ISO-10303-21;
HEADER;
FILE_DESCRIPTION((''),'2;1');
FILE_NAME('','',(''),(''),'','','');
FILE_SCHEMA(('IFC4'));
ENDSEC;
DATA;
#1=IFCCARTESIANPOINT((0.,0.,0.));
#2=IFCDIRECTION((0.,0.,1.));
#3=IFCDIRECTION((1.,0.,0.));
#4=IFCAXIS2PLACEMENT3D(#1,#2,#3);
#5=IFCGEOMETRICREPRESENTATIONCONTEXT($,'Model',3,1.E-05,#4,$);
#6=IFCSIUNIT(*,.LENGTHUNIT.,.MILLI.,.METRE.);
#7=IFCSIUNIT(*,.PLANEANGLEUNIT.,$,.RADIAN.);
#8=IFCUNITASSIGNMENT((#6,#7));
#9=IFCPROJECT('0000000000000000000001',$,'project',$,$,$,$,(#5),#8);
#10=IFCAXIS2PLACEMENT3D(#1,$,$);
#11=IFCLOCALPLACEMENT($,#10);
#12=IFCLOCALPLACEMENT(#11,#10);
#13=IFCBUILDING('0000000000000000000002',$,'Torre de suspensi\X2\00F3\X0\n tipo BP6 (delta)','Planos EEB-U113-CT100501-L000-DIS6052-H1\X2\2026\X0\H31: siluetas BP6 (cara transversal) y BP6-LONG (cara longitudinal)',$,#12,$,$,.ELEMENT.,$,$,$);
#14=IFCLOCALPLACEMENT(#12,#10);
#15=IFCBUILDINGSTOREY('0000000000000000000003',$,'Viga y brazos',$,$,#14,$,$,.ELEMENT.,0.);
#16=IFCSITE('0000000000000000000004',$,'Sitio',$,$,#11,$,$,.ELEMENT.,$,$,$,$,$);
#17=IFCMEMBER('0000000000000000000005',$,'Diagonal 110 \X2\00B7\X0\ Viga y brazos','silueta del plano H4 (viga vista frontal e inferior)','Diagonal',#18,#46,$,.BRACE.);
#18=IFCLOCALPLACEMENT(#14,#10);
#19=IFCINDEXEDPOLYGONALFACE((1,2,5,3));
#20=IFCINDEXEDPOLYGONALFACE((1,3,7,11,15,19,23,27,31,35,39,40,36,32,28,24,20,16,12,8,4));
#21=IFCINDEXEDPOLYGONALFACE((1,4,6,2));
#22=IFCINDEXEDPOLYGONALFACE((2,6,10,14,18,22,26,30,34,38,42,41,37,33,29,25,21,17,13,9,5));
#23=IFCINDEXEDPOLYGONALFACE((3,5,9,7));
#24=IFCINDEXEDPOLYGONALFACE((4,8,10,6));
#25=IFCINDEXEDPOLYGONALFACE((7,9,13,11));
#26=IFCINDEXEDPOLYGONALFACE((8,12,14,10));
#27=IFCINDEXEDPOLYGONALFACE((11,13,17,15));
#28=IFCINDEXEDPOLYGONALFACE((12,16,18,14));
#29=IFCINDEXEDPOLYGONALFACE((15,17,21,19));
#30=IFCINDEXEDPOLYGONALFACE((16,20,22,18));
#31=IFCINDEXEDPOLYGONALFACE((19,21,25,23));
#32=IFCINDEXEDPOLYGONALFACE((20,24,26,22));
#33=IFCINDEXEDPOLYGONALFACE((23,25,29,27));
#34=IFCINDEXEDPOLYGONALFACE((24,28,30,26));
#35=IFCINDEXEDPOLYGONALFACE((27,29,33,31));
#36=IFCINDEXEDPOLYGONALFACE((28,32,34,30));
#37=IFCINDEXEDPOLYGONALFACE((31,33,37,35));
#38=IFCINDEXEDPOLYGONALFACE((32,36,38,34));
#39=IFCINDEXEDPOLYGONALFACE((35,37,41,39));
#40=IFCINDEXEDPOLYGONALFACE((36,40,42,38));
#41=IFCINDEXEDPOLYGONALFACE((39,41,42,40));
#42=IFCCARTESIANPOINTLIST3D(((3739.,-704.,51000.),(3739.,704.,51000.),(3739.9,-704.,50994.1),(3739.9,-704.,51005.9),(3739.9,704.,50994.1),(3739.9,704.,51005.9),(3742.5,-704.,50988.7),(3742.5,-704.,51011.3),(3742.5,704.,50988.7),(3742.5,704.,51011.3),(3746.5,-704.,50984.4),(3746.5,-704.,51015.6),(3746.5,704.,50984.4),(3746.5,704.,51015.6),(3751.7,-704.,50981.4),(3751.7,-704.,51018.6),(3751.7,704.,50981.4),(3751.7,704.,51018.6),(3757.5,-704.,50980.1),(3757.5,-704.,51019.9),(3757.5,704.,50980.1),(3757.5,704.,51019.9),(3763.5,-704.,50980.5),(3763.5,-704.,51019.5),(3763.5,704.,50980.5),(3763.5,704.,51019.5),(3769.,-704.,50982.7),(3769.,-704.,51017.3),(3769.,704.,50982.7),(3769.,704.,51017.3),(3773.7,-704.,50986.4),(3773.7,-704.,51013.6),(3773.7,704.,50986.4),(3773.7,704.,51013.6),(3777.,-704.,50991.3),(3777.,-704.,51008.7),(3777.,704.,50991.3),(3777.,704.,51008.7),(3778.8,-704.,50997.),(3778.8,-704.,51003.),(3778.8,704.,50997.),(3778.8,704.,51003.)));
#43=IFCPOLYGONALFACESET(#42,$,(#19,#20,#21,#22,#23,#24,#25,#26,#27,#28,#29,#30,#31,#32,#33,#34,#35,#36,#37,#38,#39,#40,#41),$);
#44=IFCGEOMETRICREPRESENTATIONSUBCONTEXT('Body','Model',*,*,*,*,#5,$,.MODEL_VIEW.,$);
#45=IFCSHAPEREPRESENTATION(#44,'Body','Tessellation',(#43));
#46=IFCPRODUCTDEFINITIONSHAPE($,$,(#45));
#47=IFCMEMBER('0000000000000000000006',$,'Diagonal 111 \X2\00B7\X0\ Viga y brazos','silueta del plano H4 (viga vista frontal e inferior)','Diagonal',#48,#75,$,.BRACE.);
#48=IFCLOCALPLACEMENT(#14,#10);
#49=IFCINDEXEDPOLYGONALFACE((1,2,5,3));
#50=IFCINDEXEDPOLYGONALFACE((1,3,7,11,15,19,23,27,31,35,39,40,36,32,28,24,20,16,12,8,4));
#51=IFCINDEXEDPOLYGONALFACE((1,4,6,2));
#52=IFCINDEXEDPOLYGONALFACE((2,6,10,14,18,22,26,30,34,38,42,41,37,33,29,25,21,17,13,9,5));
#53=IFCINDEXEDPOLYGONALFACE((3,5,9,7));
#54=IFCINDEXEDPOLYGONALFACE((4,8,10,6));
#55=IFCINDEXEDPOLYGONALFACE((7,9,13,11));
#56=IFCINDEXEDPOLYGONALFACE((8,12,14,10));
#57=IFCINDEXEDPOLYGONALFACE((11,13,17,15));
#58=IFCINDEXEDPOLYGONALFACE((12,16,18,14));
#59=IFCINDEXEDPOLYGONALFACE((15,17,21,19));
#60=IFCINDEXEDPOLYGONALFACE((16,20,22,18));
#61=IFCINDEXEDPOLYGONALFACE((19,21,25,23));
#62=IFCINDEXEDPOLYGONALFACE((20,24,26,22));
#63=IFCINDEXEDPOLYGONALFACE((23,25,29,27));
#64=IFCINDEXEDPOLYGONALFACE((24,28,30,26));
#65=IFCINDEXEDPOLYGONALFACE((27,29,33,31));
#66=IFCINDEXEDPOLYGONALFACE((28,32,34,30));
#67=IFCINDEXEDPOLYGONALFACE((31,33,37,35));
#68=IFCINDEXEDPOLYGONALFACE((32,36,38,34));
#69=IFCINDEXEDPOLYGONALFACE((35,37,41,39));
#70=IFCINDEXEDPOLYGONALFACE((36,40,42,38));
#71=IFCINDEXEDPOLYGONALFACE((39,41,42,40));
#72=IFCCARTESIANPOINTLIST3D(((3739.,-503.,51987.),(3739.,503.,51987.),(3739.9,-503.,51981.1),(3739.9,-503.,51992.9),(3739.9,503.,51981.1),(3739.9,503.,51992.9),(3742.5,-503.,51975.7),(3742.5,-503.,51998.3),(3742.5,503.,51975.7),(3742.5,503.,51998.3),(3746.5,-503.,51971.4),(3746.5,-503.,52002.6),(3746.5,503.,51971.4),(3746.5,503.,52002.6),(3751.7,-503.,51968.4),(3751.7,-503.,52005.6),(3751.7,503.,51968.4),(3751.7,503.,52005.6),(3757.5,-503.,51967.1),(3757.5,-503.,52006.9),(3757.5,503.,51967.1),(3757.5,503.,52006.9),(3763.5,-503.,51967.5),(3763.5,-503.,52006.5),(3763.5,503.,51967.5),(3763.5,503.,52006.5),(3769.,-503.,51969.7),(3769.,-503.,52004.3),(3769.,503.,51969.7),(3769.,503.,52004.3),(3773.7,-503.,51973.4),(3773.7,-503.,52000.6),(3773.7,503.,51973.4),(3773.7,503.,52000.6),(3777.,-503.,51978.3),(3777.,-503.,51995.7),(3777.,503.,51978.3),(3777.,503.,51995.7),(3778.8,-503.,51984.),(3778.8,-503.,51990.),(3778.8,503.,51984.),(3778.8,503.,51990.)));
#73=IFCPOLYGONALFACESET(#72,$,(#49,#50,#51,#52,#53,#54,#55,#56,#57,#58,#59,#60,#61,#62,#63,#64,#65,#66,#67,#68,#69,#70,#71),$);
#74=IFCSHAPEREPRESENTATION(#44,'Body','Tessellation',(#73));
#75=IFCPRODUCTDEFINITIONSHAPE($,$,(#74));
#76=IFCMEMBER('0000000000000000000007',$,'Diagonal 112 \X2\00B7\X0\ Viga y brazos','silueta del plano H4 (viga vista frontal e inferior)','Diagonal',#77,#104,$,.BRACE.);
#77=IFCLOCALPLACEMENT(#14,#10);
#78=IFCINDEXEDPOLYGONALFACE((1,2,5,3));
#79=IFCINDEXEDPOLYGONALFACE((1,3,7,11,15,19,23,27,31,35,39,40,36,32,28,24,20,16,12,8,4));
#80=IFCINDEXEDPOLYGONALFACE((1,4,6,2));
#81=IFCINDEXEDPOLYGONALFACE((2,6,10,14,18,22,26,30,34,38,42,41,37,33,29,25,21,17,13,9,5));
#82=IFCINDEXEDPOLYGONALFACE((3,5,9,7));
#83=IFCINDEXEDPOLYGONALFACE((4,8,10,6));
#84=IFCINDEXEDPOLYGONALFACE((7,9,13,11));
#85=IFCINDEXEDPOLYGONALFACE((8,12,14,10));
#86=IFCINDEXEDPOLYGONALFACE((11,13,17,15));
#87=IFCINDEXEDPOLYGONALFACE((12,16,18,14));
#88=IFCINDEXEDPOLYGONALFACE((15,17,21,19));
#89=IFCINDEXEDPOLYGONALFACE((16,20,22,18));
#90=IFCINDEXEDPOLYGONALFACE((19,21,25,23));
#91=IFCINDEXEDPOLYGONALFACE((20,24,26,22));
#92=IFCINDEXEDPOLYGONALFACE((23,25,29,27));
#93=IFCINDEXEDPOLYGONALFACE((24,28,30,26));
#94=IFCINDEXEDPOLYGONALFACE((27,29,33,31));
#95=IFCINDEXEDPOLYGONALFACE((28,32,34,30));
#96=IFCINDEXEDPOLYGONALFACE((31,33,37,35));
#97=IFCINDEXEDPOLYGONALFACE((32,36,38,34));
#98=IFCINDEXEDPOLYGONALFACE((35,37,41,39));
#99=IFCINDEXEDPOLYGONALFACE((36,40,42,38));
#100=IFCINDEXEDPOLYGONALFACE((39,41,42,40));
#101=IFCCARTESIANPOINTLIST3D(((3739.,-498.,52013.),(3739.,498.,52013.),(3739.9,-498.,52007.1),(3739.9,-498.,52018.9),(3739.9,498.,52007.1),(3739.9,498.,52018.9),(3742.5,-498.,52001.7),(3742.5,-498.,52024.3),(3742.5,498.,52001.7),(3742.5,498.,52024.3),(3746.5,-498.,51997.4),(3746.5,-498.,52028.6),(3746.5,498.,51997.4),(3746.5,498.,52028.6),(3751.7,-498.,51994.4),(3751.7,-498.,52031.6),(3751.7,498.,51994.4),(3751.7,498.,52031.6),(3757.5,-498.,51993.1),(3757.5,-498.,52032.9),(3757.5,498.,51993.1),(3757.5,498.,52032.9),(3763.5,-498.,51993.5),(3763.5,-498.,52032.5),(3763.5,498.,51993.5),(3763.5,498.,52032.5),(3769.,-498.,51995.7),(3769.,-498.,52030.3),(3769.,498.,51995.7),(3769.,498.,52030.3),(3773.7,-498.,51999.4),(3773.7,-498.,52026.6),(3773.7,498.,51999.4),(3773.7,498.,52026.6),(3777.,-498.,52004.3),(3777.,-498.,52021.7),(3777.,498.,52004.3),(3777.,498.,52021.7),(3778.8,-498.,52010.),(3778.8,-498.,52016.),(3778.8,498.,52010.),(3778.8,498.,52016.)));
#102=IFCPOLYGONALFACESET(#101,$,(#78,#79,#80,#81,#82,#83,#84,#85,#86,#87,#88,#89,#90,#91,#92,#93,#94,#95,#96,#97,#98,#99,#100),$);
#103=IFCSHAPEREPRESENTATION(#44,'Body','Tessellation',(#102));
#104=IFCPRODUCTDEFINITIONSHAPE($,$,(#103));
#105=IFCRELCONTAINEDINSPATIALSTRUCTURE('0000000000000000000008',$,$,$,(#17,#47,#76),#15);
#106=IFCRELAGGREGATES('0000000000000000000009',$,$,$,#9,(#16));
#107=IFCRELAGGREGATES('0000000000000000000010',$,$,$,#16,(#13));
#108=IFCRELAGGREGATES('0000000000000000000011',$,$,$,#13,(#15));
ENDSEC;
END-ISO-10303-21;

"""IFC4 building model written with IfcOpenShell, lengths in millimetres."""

from ifc_helpers import new_model, si_unit, frame, origin, origin_with_axes, place, context, subcontext, project, spatial, circle, extrude, element, save


model = new_model("IFC4")

# Units and contexts
model_context = context("Model", 3, precision=1e-05, world=origin_with_axes())
body_context = subcontext(model_context, "Body", "Model", "MODEL_VIEW")
ifc_project = project(units=[si_unit("LENGTHUNIT", "METRE", prefix="MILLI"), si_unit("PLANEANGLEUNIT", "RADIAN")], contexts=[model_context])

# Site, building, storey
site_placement = place(None, origin())
site = spatial("IfcSite", under=ifc_project, at=site_placement, Name="Sitio", CompositionType="ELEMENT")
building_placement = place(site_placement, origin())
building = spatial("IfcBuilding", under=site, at=building_placement, Name="Torre de suspensión tipo BP6 (delta)", Description="Planos EEB-U113-CT100501-L000-DIS6052-H1…H31: siluetas BP6 (cara transversal) y BP6-LONG (cara longitudinal)", CompositionType="ELEMENT")
storey_placement = place(building_placement, origin())
storey = spatial("IfcBuildingStorey", under=building, at=storey_placement, Name="Viga y brazos", CompositionType="ELEMENT", Elevation=0.0)

# Members
for number, where, z_axis, x_axis, name in (
    (1, (3759.0, 704.0, 51000.0), (0.0, -1.0, 0.0), (-1.0, 0.0, 0.0), "Diagonal 110 · Viga y brazos"),
):
    element("IfcMember", number, at=place(storey_placement, frame(where, z_axis=z_axis, x_axis=x_axis)), inside=storey, Name=name, Description="silueta del plano H4 (viga vista frontal e inferior)", ObjectType="Diagonal", PredefinedType="BRACE", context=body_context, shape_type="SweptSolid", body=[
        extrude(circle(Radius=20.0), None, (0.0, 0.0, 1.0), 1408.0),
    ])
member_1_placement = place(storey_placement, frame((3759.0, 503.0, 51987.0), z_axis=(0.0, -1.0, 0.0), x_axis=(-1.0, 0.0, 0.0)))
element("IfcMember", 2, at=member_1_placement, inside=storey, Name="Diagonal 111 · Viga y brazos", Description="silueta del plano H4 (viga vista frontal e inferior)", ObjectType="Diagonal", PredefinedType="BRACE", context=body_context, shape_type="SweptSolid", body=[
    extrude(circle(Radius=20.0), None, (0.0, 0.0, 1.0), 1006.0),
])
member_2_placement = place(storey_placement, frame((3759.0, 498.0, 52013.0), z_axis=(0.0, -1.0, 0.0), x_axis=(-1.0, 0.0, 0.0)))
element("IfcMember", 3, at=member_2_placement, inside=storey, Name="Diagonal 112 · Viga y brazos", Description="silueta del plano H4 (viga vista frontal e inferior)", ObjectType="Diagonal", PredefinedType="BRACE", context=body_context, shape_type="SweptSolid", body=[
    extrude(circle(Radius=20.0), None, (0.0, 0.0, 1.0), 996.0),
])

save(model, "model.ifc")
